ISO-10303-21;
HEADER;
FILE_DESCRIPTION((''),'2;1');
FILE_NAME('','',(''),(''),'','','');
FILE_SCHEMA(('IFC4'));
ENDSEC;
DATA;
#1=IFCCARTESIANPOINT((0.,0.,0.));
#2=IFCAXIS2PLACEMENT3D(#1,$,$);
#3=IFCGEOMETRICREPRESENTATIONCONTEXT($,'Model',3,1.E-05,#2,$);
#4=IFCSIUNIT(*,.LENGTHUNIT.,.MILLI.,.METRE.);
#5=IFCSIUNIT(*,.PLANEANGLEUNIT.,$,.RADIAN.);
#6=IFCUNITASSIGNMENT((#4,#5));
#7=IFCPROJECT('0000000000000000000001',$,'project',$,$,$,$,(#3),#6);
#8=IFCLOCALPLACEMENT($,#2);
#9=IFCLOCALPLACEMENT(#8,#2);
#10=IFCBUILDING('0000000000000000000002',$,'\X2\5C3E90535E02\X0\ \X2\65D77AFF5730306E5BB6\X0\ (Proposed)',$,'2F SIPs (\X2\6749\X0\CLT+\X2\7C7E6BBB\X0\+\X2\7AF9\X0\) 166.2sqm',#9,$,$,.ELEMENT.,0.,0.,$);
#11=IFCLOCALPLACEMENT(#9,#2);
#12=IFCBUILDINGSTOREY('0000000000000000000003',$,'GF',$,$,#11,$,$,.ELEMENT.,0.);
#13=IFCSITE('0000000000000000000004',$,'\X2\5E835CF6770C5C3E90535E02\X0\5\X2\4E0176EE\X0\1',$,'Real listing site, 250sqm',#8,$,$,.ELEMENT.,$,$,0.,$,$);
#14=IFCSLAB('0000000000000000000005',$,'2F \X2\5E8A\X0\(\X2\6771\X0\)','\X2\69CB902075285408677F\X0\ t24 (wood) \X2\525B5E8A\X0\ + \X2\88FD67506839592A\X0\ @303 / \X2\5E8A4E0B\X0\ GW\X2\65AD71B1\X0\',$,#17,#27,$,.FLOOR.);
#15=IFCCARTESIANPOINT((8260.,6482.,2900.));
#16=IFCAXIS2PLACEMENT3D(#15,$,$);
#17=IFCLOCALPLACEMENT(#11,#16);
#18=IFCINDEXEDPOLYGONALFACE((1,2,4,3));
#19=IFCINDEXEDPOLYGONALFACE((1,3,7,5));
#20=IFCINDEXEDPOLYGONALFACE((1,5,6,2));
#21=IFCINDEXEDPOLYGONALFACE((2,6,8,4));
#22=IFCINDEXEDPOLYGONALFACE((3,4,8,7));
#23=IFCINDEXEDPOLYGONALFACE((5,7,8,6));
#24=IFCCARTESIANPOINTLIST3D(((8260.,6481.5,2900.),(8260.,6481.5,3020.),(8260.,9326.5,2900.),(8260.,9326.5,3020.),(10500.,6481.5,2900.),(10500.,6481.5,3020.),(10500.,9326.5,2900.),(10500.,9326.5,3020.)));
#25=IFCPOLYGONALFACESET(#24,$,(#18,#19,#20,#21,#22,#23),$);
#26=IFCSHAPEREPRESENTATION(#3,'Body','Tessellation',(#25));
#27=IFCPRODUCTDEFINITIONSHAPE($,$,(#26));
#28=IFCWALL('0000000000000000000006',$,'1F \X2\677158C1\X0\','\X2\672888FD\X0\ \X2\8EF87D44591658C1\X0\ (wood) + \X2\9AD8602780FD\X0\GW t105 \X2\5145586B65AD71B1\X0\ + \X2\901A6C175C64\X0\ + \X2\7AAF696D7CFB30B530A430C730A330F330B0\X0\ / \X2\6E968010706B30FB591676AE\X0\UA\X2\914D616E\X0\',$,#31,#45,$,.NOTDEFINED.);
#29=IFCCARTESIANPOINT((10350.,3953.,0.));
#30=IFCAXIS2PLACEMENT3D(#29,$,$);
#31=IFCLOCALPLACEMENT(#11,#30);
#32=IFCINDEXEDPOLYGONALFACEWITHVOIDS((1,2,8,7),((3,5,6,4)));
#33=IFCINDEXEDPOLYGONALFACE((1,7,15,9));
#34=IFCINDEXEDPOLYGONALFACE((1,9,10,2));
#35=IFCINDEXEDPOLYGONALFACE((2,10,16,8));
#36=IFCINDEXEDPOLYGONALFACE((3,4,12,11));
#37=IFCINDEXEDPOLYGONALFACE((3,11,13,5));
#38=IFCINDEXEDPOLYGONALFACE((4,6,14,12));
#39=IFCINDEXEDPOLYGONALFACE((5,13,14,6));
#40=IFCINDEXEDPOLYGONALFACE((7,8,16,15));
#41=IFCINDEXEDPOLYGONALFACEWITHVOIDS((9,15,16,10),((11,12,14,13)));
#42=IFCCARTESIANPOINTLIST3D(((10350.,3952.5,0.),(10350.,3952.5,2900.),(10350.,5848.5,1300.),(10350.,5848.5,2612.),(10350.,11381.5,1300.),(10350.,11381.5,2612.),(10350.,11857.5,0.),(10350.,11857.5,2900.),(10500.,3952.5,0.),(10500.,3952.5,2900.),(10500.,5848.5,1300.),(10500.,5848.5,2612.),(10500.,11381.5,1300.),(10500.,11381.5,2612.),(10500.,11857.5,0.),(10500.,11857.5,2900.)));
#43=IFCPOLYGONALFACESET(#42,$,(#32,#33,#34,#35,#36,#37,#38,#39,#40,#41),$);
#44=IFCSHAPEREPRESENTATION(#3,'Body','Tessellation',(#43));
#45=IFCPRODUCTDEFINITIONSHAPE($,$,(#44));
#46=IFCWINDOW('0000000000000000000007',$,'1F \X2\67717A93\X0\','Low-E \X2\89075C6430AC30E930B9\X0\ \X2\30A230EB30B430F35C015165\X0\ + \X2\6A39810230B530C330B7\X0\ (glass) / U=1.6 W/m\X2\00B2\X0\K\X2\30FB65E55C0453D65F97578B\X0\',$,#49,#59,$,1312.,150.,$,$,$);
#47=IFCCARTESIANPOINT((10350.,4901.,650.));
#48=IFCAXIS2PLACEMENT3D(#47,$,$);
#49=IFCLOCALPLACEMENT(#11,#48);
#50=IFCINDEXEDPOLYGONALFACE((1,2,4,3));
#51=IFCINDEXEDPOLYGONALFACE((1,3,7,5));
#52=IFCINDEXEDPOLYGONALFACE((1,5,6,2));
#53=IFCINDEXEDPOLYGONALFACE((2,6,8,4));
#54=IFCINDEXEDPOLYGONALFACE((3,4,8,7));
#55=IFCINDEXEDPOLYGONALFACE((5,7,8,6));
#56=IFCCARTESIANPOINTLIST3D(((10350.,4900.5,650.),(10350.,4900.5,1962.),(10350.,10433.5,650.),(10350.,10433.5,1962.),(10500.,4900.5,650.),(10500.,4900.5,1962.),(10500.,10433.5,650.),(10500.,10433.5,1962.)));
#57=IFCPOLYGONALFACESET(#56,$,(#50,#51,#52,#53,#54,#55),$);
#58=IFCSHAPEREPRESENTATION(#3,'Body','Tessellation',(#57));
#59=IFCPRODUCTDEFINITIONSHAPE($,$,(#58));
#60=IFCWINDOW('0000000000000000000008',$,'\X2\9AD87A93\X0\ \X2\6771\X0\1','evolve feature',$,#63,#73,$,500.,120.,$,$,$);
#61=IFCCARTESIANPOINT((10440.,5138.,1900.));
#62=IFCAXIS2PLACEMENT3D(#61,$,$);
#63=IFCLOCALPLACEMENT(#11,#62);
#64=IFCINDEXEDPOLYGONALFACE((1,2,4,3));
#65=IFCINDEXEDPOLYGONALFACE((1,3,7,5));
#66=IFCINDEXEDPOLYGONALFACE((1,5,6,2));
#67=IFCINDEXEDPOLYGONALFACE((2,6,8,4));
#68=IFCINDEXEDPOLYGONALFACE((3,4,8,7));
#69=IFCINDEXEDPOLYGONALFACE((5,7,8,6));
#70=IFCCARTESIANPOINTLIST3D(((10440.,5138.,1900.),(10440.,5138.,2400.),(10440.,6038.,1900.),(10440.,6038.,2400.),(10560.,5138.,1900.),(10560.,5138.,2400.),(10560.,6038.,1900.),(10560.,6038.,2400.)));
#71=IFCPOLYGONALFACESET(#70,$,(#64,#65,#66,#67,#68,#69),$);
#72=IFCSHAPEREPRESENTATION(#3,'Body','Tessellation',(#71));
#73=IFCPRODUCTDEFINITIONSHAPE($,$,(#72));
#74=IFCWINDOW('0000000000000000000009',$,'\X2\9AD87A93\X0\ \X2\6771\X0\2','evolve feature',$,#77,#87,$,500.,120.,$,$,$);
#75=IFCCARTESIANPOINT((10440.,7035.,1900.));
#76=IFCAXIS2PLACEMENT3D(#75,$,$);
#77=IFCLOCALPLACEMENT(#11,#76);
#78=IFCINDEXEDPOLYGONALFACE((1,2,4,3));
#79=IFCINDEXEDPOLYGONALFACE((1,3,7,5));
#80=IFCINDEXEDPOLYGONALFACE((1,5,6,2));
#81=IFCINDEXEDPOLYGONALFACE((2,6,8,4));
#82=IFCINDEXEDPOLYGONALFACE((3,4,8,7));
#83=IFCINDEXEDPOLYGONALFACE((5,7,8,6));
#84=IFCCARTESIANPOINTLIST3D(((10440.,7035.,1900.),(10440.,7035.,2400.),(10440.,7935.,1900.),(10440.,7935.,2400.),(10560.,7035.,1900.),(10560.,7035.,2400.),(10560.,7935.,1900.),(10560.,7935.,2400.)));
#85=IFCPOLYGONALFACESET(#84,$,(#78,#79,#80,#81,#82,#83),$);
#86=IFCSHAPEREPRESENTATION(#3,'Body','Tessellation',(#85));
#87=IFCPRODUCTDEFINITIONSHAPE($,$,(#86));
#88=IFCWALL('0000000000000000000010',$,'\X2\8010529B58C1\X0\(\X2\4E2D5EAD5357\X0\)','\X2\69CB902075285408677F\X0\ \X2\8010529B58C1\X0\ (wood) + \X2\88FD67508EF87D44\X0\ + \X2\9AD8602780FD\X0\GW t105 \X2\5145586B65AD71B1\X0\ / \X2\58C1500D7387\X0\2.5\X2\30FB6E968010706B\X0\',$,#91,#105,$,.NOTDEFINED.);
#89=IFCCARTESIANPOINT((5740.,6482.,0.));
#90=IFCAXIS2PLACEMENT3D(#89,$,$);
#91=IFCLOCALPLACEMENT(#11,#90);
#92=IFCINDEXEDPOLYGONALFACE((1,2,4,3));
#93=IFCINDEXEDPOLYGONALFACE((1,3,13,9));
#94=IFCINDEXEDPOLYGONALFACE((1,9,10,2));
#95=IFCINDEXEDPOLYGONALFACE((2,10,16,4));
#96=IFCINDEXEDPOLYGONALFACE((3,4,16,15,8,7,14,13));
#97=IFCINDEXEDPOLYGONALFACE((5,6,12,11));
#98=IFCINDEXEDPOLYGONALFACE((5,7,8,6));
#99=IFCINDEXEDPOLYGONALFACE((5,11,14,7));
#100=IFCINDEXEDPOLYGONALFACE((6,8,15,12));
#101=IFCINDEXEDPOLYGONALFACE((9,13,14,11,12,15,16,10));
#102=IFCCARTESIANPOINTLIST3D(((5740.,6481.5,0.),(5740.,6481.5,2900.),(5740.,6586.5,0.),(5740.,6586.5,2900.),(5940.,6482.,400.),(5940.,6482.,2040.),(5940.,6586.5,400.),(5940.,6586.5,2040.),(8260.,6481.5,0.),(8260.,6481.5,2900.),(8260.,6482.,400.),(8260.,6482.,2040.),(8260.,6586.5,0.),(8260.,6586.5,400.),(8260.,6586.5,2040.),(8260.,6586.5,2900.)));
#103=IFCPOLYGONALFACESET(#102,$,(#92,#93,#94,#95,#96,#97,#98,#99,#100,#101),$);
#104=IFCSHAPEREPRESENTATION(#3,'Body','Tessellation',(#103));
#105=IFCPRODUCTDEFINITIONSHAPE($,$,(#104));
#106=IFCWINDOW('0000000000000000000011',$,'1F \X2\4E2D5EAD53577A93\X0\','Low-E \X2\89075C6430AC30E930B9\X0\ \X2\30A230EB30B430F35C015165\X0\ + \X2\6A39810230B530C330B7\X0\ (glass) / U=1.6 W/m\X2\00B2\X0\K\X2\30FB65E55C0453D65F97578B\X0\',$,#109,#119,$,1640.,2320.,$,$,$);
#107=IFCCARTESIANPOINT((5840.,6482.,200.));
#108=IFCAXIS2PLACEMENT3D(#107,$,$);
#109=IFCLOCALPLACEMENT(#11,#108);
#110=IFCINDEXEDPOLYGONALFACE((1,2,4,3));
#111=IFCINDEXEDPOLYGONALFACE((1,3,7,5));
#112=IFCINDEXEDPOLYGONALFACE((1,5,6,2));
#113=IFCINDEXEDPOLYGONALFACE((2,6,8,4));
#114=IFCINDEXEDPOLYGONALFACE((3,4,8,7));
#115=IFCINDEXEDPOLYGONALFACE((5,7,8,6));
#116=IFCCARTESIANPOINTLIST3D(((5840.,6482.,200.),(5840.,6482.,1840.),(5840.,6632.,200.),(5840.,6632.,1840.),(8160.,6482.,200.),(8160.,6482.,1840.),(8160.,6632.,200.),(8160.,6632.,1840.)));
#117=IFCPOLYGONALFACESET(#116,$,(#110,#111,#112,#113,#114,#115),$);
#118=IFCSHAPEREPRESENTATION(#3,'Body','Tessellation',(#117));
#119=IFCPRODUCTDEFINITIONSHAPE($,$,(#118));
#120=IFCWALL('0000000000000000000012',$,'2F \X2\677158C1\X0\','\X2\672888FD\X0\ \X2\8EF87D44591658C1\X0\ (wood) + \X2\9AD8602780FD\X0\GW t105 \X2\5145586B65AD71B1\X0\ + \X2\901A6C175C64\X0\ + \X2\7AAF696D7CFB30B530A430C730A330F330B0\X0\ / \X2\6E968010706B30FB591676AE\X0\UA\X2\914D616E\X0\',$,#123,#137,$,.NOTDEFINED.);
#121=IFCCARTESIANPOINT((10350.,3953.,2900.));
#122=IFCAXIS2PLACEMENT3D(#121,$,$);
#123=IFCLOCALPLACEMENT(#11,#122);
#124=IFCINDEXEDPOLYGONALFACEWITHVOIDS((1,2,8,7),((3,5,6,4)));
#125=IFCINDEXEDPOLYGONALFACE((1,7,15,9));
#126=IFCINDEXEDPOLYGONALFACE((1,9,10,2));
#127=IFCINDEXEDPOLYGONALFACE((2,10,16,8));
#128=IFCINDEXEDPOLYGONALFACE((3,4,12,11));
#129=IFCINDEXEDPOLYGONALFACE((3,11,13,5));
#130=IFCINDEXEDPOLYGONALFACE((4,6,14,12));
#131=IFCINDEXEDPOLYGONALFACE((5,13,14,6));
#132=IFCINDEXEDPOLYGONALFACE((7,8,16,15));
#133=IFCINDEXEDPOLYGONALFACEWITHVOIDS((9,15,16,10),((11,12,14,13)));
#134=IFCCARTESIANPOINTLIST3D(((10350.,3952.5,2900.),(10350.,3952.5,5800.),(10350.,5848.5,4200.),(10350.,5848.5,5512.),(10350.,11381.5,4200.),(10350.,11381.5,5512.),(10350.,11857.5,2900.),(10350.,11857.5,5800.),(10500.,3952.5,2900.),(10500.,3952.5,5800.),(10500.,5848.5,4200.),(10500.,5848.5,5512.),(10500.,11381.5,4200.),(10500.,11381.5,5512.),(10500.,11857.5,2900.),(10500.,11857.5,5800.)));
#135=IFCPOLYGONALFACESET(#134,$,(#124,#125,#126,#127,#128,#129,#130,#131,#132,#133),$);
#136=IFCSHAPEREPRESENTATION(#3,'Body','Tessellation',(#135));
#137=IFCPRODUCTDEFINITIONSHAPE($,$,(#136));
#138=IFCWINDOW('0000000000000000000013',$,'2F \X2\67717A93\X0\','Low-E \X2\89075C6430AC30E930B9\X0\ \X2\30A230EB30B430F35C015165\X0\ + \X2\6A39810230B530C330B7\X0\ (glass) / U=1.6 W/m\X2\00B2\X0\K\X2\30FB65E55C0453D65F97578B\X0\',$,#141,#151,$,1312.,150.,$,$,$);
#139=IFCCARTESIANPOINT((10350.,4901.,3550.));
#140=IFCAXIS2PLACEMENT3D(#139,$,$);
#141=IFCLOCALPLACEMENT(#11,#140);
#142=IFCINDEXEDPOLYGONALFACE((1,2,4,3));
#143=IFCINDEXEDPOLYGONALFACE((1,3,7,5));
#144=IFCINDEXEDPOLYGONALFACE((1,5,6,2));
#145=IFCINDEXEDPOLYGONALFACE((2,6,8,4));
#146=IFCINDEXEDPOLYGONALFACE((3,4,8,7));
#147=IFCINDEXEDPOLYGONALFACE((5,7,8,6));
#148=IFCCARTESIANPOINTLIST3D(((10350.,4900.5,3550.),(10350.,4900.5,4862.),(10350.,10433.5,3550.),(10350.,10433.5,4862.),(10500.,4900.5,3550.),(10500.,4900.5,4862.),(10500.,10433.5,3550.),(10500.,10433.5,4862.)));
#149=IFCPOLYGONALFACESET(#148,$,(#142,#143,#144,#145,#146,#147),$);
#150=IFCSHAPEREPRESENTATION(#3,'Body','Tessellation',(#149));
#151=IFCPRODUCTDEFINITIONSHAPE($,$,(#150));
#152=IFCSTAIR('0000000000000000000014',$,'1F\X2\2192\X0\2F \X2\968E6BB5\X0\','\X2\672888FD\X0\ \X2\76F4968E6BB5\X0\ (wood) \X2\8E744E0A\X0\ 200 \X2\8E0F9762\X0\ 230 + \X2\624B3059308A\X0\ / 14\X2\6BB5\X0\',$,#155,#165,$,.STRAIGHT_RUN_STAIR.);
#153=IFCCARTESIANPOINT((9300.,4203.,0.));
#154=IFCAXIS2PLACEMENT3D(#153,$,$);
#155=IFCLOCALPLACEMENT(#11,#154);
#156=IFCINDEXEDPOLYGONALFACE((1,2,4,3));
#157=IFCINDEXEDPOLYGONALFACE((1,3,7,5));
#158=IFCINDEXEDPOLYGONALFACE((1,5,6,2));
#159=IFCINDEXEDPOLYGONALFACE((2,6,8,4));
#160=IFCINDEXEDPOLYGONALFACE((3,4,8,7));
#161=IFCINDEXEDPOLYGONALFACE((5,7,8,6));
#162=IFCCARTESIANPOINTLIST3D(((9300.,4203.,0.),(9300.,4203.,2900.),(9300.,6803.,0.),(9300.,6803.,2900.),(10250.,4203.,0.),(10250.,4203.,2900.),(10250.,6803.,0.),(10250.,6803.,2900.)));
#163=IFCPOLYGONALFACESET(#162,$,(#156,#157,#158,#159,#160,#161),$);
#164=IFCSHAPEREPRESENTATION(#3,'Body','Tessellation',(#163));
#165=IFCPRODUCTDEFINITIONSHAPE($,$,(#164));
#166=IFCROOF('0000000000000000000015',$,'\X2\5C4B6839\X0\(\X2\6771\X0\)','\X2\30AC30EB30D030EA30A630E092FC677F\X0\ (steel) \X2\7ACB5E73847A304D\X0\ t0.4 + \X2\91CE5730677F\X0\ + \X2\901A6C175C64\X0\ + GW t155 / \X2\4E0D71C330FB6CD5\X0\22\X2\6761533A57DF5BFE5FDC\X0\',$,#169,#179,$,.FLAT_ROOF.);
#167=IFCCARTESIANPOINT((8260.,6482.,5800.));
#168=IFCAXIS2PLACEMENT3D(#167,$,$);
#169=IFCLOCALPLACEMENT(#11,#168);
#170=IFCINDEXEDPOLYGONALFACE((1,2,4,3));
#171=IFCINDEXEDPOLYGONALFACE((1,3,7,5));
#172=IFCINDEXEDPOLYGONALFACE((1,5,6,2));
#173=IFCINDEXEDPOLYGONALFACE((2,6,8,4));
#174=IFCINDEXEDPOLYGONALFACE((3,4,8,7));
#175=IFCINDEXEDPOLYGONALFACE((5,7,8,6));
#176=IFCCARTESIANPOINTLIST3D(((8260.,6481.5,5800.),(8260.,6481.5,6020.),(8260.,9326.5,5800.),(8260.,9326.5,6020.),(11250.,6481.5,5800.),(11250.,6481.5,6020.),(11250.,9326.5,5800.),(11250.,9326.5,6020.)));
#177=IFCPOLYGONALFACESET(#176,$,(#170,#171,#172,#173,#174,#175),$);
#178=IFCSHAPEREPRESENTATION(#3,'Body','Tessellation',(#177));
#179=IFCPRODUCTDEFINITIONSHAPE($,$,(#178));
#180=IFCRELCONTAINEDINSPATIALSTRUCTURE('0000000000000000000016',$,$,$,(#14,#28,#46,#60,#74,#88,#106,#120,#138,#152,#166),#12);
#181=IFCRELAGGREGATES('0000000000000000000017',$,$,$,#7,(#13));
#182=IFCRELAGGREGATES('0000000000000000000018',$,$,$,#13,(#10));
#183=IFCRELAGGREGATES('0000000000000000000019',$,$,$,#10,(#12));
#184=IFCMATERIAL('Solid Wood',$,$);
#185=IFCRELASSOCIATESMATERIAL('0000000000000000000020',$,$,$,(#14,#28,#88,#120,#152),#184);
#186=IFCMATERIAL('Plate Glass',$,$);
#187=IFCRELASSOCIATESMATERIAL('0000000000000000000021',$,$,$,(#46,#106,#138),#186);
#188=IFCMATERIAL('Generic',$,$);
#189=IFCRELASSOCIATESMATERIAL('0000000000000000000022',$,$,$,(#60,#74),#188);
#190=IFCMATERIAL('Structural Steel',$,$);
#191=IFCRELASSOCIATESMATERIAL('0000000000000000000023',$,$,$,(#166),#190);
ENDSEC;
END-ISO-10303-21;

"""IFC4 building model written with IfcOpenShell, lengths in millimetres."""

from ifc_helpers import new_model, si_unit, frame, frame_2d, origin, place, context, project, spatial, rectangle, extrude, material, element, fill, save


model = new_model("IFC4")

# Units and contexts
model_context = context("Model", 3, precision=1e-05, world=origin())
ifc_project = project(units=[si_unit("LENGTHUNIT", "METRE", prefix="MILLI"), si_unit("PLANEANGLEUNIT", "RADIAN")], contexts=[model_context])

# Site, building, storey
site_placement = place(None, origin())
site = spatial("IfcSite", under=ifc_project, at=site_placement, Name="広島県尾道市5丁目1", ObjectType="Real listing site, 250sqm", CompositionType="ELEMENT", RefElevation=0.0)
building_placement = place(site_placement, origin())
building = spatial("IfcBuilding", under=site, at=building_placement, Name="尾道市 旗竿地の家 (Proposed)", ObjectType="2F SIPs (杉CLT+籾殻+竹) 166.2sqm", CompositionType="ELEMENT", ElevationOfRefHeight=0.0, ElevationOfTerrain=0.0)
storey_placement = place(building_placement, origin())
storey = spatial("IfcBuildingStorey", under=building, at=storey_placement, Name="GF", CompositionType="ELEMENT", Elevation=0.0)

# Slab
ifc_material_1 = material(Name="Solid Wood")
slab_1_placement = place(storey_placement, frame((8260.0, 6482.0, 2900.0)))
element("IfcSlab", 1, at=slab_1_placement, inside=storey, material=ifc_material_1, Name="2F 床(東)", Description="構造用合板 t24 (wood) 剛床 + 製材根太 @303 / 床下 GW断熱", PredefinedType="FLOOR", context=model_context, shape_type="SweptSolid", body=[
    extrude(rectangle(XDim=2240.0, YDim=2845.0, at=frame_2d((1120.0, 1422.0))), frame((8260.0, 6482.0, 2900.0)), (0.0, 0.0, 1.0), 120.0),
])

# Wall, openings, windows
wall_1_placement = place(storey_placement, frame((10350.0, 3953.0, 0.0)))
wall_1 = element("IfcWall", 2, at=wall_1_placement, inside=storey, material=ifc_material_1, Name="1F 東壁", Description="木製 軸組外壁 (wood) + 高性能GW t105 充填断熱 + 通気層 + 窯業系サイディング / 準耐火・外皮UA配慮", PredefinedType="NOTDEFINED", context=model_context, shape_type="SweptSolid", body=[
    extrude(rectangle(XDim=150.0, YDim=7905.0, at=frame_2d((75.0, 3952.0))), frame((10350.0, 3953.0, 0.0)), (0.0, 0.0, 1.0), 2900.0),
])
opening_1_placement = place(storey_placement, frame((10350.0, 4901.0, 650.0)))
opening_1 = element("IfcOpeningElement", 3, at=opening_1_placement, cuts=wall_1, PredefinedType="NOTDEFINED", context=model_context, shape_type="SweptSolid", body=[
    extrude(rectangle(XDim=150.0, YDim=5533.0, at=frame_2d((75.0, 2766.0))), frame((10350.0, 4901.0, 650.0)), (0.0, 0.0, 1.0), 1312.0),
])
opening_2_placement = place(storey_placement, frame((10440.0, 5138.0, 1900.0)))
opening_2 = element("IfcOpeningElement", 4, at=opening_2_placement, cuts=wall_1, PredefinedType="NOTDEFINED", context=model_context, shape_type="SweptSolid", body=[
    extrude(rectangle(XDim=120.0, YDim=900.0, at=frame_2d((60.0, 450.0))), frame((10440.0, 5138.0, 1900.0)), (0.0, 0.0, 1.0), 500.0),
])
opening_3_placement = place(storey_placement, frame((10440.0, 7035.0, 1900.0)))
opening_3 = element("IfcOpeningElement", 5, at=opening_3_placement, cuts=wall_1, PredefinedType="NOTDEFINED", context=model_context, shape_type="SweptSolid", body=[
    extrude(rectangle(XDim=120.0, YDim=900.0, at=frame_2d((60.0, 450.0))), frame((10440.0, 7035.0, 1900.0)), (0.0, 0.0, 1.0), 500.0),
])
ifc_material_2 = material(Name="Plate Glass")
window_1_placement = place(storey_placement, frame((10350.0, 4901.0, 650.0)))
window_1 = element("IfcWindow", 6, at=window_1_placement, inside=storey, material=ifc_material_2, Name="1F 東窓", Description="Low-E 複層ガラス アルゴン封入 + 樹脂サッシ (glass) / U=1.6 W/m²K・日射取得型", OverallHeight=1312.0, OverallWidth=150.0, context=model_context, shape_type="SweptSolid", body=[
    extrude(rectangle(XDim=150.0, YDim=5533.0, at=frame_2d((75.0, 2766.0))), frame((10350.0, 4901.0, 650.0)), (0.0, 0.0, 1.0), 1312.0),
])
fill(opening_1, window_1)
ifc_material_3 = material(Name="Generic")
window_2_placement = place(storey_placement, frame((10440.0, 5138.0, 1900.0)))
window_2 = element("IfcWindow", 7, at=window_2_placement, inside=storey, material=ifc_material_3, Name="高窓 東1", Description="evolve feature", OverallHeight=500.0, OverallWidth=120.0, context=model_context, shape_type="SweptSolid", body=[
    extrude(rectangle(XDim=120.0, YDim=900.0, at=frame_2d((60.0, 450.0))), frame((10440.0, 5138.0, 1900.0)), (0.0, 0.0, 1.0), 500.0),
])
fill(opening_2, window_2)
window_3_placement = place(storey_placement, frame((10440.0, 7035.0, 1900.0)))
window_3 = element("IfcWindow", 8, at=window_3_placement, inside=storey, material=ifc_material_3, Name="高窓 東2", Description="evolve feature", OverallHeight=500.0, OverallWidth=120.0, context=model_context, shape_type="SweptSolid", body=[
    extrude(rectangle(XDim=120.0, YDim=900.0, at=frame_2d((60.0, 450.0))), frame((10440.0, 7035.0, 1900.0)), (0.0, 0.0, 1.0), 500.0),
])
fill(opening_3, window_3)

# Wall, opening, window
wall_2_placement = place(storey_placement, frame((5740.0, 6482.0, 0.0)))
wall_2 = element("IfcWall", 9, at=wall_2_placement, inside=storey, material=ifc_material_1, Name="耐力壁(中庭南)", Description="構造用合板 耐力壁 (wood) + 製材軸組 + 高性能GW t105 充填断熱 / 壁倍率2.5・準耐火", PredefinedType="NOTDEFINED", context=model_context, shape_type="SweptSolid", body=[
    extrude(rectangle(XDim=2520.0, YDim=105.0, at=frame_2d((1260.0, 52.0))), frame((5740.0, 6482.0, 0.0)), (0.0, 0.0, 1.0), 2900.0),
])
opening_4_placement = place(storey_placement, frame((5840.0, 6482.0, 200.0)))
opening_4 = element("IfcOpeningElement", 10, at=opening_4_placement, cuts=wall_2, PredefinedType="NOTDEFINED", context=model_context, shape_type="SweptSolid", body=[
    extrude(rectangle(XDim=2320.0, YDim=150.0, at=frame_2d((1160.0, 75.0))), frame((5840.0, 6482.0, 200.0)), (0.0, 0.0, 1.0), 1640.0),
])
window_4_placement = place(storey_placement, frame((5840.0, 6482.0, 200.0)))
window_4 = element("IfcWindow", 11, at=window_4_placement, inside=storey, material=ifc_material_2, Name="1F 中庭南窓", Description="Low-E 複層ガラス アルゴン封入 + 樹脂サッシ (glass) / U=1.6 W/m²K・日射取得型", OverallHeight=1640.0, OverallWidth=2320.0, context=model_context, shape_type="SweptSolid", body=[
    extrude(rectangle(XDim=2320.0, YDim=150.0, at=frame_2d((1160.0, 75.0))), frame((5840.0, 6482.0, 200.0)), (0.0, 0.0, 1.0), 1640.0),
])
fill(opening_4, window_4)

# Wall, opening, window
wall_3_placement = place(storey_placement, frame((10350.0, 3953.0, 2900.0)))
wall_3 = element("IfcWall", 12, at=wall_3_placement, inside=storey, material=ifc_material_1, Name="2F 東壁", Description="木製 軸組外壁 (wood) + 高性能GW t105 充填断熱 + 通気層 + 窯業系サイディング / 準耐火・外皮UA配慮", PredefinedType="NOTDEFINED", context=model_context, shape_type="SweptSolid", body=[
    extrude(rectangle(XDim=150.0, YDim=7905.0, at=frame_2d((75.0, 3952.0))), frame((10350.0, 3953.0, 2900.0)), (0.0, 0.0, 1.0), 2900.0),
])
opening_5_placement = place(storey_placement, frame((10350.0, 4901.0, 3550.0)))
opening_5 = element("IfcOpeningElement", 13, at=opening_5_placement, cuts=wall_3, PredefinedType="NOTDEFINED", context=model_context, shape_type="SweptSolid", body=[
    extrude(rectangle(XDim=150.0, YDim=5533.0, at=frame_2d((75.0, 2766.0))), frame((10350.0, 4901.0, 3550.0)), (0.0, 0.0, 1.0), 1312.0),
])
window_5_placement = place(storey_placement, frame((10350.0, 4901.0, 3550.0)))
window_5 = element("IfcWindow", 14, at=window_5_placement, inside=storey, material=ifc_material_2, Name="2F 東窓", Description="Low-E 複層ガラス アルゴン封入 + 樹脂サッシ (glass) / U=1.6 W/m²K・日射取得型", OverallHeight=1312.0, OverallWidth=150.0, context=model_context, shape_type="SweptSolid", body=[
    extrude(rectangle(XDim=150.0, YDim=5533.0, at=frame_2d((75.0, 2766.0))), frame((10350.0, 4901.0, 3550.0)), (0.0, 0.0, 1.0), 1312.0),
])
fill(opening_5, window_5)

# Stair
stair_placement = place(storey_placement, frame((9300.0, 4203.0, 0.0)))
element("IfcStair", 15, at=stair_placement, inside=storey, material=ifc_material_1, Name="1F→2F 階段", Description="木製 直階段 (wood) 蹴上 200 踏面 230 + 手すり / 14段", PredefinedType="STRAIGHT_RUN_STAIR", context=model_context, shape_type="SweptSolid", body=[
    extrude(rectangle(XDim=950.0, YDim=2600.0, at=frame_2d((475.0, 1300.0))), frame((9300.0, 4203.0, 0.0)), (0.0, 0.0, 1.0), 2900.0),
])

# Roof
ifc_material_4 = material(Name="Structural Steel")
roof_placement = place(storey_placement, frame((8260.0, 6482.0, 5800.0)))
element("IfcRoof", 16, at=roof_placement, inside=storey, material=ifc_material_4, Name="屋根(東)", Description="ガルバリウム鋼板 (steel) 立平葺き t0.4 + 野地板 + 通気層 + GW t155 / 不燃・法22条区域対応", PredefinedType="FLAT_ROOF", context=model_context, shape_type="SweptSolid", body=[
    extrude(rectangle(XDim=2990.0, YDim=2845.0, at=frame_2d((1495.0, 1422.0))), frame((8260.0, 6482.0, 5800.0)), (0.0, 0.0, 1.0), 220.0),
])

save(model, "model.ifc")
